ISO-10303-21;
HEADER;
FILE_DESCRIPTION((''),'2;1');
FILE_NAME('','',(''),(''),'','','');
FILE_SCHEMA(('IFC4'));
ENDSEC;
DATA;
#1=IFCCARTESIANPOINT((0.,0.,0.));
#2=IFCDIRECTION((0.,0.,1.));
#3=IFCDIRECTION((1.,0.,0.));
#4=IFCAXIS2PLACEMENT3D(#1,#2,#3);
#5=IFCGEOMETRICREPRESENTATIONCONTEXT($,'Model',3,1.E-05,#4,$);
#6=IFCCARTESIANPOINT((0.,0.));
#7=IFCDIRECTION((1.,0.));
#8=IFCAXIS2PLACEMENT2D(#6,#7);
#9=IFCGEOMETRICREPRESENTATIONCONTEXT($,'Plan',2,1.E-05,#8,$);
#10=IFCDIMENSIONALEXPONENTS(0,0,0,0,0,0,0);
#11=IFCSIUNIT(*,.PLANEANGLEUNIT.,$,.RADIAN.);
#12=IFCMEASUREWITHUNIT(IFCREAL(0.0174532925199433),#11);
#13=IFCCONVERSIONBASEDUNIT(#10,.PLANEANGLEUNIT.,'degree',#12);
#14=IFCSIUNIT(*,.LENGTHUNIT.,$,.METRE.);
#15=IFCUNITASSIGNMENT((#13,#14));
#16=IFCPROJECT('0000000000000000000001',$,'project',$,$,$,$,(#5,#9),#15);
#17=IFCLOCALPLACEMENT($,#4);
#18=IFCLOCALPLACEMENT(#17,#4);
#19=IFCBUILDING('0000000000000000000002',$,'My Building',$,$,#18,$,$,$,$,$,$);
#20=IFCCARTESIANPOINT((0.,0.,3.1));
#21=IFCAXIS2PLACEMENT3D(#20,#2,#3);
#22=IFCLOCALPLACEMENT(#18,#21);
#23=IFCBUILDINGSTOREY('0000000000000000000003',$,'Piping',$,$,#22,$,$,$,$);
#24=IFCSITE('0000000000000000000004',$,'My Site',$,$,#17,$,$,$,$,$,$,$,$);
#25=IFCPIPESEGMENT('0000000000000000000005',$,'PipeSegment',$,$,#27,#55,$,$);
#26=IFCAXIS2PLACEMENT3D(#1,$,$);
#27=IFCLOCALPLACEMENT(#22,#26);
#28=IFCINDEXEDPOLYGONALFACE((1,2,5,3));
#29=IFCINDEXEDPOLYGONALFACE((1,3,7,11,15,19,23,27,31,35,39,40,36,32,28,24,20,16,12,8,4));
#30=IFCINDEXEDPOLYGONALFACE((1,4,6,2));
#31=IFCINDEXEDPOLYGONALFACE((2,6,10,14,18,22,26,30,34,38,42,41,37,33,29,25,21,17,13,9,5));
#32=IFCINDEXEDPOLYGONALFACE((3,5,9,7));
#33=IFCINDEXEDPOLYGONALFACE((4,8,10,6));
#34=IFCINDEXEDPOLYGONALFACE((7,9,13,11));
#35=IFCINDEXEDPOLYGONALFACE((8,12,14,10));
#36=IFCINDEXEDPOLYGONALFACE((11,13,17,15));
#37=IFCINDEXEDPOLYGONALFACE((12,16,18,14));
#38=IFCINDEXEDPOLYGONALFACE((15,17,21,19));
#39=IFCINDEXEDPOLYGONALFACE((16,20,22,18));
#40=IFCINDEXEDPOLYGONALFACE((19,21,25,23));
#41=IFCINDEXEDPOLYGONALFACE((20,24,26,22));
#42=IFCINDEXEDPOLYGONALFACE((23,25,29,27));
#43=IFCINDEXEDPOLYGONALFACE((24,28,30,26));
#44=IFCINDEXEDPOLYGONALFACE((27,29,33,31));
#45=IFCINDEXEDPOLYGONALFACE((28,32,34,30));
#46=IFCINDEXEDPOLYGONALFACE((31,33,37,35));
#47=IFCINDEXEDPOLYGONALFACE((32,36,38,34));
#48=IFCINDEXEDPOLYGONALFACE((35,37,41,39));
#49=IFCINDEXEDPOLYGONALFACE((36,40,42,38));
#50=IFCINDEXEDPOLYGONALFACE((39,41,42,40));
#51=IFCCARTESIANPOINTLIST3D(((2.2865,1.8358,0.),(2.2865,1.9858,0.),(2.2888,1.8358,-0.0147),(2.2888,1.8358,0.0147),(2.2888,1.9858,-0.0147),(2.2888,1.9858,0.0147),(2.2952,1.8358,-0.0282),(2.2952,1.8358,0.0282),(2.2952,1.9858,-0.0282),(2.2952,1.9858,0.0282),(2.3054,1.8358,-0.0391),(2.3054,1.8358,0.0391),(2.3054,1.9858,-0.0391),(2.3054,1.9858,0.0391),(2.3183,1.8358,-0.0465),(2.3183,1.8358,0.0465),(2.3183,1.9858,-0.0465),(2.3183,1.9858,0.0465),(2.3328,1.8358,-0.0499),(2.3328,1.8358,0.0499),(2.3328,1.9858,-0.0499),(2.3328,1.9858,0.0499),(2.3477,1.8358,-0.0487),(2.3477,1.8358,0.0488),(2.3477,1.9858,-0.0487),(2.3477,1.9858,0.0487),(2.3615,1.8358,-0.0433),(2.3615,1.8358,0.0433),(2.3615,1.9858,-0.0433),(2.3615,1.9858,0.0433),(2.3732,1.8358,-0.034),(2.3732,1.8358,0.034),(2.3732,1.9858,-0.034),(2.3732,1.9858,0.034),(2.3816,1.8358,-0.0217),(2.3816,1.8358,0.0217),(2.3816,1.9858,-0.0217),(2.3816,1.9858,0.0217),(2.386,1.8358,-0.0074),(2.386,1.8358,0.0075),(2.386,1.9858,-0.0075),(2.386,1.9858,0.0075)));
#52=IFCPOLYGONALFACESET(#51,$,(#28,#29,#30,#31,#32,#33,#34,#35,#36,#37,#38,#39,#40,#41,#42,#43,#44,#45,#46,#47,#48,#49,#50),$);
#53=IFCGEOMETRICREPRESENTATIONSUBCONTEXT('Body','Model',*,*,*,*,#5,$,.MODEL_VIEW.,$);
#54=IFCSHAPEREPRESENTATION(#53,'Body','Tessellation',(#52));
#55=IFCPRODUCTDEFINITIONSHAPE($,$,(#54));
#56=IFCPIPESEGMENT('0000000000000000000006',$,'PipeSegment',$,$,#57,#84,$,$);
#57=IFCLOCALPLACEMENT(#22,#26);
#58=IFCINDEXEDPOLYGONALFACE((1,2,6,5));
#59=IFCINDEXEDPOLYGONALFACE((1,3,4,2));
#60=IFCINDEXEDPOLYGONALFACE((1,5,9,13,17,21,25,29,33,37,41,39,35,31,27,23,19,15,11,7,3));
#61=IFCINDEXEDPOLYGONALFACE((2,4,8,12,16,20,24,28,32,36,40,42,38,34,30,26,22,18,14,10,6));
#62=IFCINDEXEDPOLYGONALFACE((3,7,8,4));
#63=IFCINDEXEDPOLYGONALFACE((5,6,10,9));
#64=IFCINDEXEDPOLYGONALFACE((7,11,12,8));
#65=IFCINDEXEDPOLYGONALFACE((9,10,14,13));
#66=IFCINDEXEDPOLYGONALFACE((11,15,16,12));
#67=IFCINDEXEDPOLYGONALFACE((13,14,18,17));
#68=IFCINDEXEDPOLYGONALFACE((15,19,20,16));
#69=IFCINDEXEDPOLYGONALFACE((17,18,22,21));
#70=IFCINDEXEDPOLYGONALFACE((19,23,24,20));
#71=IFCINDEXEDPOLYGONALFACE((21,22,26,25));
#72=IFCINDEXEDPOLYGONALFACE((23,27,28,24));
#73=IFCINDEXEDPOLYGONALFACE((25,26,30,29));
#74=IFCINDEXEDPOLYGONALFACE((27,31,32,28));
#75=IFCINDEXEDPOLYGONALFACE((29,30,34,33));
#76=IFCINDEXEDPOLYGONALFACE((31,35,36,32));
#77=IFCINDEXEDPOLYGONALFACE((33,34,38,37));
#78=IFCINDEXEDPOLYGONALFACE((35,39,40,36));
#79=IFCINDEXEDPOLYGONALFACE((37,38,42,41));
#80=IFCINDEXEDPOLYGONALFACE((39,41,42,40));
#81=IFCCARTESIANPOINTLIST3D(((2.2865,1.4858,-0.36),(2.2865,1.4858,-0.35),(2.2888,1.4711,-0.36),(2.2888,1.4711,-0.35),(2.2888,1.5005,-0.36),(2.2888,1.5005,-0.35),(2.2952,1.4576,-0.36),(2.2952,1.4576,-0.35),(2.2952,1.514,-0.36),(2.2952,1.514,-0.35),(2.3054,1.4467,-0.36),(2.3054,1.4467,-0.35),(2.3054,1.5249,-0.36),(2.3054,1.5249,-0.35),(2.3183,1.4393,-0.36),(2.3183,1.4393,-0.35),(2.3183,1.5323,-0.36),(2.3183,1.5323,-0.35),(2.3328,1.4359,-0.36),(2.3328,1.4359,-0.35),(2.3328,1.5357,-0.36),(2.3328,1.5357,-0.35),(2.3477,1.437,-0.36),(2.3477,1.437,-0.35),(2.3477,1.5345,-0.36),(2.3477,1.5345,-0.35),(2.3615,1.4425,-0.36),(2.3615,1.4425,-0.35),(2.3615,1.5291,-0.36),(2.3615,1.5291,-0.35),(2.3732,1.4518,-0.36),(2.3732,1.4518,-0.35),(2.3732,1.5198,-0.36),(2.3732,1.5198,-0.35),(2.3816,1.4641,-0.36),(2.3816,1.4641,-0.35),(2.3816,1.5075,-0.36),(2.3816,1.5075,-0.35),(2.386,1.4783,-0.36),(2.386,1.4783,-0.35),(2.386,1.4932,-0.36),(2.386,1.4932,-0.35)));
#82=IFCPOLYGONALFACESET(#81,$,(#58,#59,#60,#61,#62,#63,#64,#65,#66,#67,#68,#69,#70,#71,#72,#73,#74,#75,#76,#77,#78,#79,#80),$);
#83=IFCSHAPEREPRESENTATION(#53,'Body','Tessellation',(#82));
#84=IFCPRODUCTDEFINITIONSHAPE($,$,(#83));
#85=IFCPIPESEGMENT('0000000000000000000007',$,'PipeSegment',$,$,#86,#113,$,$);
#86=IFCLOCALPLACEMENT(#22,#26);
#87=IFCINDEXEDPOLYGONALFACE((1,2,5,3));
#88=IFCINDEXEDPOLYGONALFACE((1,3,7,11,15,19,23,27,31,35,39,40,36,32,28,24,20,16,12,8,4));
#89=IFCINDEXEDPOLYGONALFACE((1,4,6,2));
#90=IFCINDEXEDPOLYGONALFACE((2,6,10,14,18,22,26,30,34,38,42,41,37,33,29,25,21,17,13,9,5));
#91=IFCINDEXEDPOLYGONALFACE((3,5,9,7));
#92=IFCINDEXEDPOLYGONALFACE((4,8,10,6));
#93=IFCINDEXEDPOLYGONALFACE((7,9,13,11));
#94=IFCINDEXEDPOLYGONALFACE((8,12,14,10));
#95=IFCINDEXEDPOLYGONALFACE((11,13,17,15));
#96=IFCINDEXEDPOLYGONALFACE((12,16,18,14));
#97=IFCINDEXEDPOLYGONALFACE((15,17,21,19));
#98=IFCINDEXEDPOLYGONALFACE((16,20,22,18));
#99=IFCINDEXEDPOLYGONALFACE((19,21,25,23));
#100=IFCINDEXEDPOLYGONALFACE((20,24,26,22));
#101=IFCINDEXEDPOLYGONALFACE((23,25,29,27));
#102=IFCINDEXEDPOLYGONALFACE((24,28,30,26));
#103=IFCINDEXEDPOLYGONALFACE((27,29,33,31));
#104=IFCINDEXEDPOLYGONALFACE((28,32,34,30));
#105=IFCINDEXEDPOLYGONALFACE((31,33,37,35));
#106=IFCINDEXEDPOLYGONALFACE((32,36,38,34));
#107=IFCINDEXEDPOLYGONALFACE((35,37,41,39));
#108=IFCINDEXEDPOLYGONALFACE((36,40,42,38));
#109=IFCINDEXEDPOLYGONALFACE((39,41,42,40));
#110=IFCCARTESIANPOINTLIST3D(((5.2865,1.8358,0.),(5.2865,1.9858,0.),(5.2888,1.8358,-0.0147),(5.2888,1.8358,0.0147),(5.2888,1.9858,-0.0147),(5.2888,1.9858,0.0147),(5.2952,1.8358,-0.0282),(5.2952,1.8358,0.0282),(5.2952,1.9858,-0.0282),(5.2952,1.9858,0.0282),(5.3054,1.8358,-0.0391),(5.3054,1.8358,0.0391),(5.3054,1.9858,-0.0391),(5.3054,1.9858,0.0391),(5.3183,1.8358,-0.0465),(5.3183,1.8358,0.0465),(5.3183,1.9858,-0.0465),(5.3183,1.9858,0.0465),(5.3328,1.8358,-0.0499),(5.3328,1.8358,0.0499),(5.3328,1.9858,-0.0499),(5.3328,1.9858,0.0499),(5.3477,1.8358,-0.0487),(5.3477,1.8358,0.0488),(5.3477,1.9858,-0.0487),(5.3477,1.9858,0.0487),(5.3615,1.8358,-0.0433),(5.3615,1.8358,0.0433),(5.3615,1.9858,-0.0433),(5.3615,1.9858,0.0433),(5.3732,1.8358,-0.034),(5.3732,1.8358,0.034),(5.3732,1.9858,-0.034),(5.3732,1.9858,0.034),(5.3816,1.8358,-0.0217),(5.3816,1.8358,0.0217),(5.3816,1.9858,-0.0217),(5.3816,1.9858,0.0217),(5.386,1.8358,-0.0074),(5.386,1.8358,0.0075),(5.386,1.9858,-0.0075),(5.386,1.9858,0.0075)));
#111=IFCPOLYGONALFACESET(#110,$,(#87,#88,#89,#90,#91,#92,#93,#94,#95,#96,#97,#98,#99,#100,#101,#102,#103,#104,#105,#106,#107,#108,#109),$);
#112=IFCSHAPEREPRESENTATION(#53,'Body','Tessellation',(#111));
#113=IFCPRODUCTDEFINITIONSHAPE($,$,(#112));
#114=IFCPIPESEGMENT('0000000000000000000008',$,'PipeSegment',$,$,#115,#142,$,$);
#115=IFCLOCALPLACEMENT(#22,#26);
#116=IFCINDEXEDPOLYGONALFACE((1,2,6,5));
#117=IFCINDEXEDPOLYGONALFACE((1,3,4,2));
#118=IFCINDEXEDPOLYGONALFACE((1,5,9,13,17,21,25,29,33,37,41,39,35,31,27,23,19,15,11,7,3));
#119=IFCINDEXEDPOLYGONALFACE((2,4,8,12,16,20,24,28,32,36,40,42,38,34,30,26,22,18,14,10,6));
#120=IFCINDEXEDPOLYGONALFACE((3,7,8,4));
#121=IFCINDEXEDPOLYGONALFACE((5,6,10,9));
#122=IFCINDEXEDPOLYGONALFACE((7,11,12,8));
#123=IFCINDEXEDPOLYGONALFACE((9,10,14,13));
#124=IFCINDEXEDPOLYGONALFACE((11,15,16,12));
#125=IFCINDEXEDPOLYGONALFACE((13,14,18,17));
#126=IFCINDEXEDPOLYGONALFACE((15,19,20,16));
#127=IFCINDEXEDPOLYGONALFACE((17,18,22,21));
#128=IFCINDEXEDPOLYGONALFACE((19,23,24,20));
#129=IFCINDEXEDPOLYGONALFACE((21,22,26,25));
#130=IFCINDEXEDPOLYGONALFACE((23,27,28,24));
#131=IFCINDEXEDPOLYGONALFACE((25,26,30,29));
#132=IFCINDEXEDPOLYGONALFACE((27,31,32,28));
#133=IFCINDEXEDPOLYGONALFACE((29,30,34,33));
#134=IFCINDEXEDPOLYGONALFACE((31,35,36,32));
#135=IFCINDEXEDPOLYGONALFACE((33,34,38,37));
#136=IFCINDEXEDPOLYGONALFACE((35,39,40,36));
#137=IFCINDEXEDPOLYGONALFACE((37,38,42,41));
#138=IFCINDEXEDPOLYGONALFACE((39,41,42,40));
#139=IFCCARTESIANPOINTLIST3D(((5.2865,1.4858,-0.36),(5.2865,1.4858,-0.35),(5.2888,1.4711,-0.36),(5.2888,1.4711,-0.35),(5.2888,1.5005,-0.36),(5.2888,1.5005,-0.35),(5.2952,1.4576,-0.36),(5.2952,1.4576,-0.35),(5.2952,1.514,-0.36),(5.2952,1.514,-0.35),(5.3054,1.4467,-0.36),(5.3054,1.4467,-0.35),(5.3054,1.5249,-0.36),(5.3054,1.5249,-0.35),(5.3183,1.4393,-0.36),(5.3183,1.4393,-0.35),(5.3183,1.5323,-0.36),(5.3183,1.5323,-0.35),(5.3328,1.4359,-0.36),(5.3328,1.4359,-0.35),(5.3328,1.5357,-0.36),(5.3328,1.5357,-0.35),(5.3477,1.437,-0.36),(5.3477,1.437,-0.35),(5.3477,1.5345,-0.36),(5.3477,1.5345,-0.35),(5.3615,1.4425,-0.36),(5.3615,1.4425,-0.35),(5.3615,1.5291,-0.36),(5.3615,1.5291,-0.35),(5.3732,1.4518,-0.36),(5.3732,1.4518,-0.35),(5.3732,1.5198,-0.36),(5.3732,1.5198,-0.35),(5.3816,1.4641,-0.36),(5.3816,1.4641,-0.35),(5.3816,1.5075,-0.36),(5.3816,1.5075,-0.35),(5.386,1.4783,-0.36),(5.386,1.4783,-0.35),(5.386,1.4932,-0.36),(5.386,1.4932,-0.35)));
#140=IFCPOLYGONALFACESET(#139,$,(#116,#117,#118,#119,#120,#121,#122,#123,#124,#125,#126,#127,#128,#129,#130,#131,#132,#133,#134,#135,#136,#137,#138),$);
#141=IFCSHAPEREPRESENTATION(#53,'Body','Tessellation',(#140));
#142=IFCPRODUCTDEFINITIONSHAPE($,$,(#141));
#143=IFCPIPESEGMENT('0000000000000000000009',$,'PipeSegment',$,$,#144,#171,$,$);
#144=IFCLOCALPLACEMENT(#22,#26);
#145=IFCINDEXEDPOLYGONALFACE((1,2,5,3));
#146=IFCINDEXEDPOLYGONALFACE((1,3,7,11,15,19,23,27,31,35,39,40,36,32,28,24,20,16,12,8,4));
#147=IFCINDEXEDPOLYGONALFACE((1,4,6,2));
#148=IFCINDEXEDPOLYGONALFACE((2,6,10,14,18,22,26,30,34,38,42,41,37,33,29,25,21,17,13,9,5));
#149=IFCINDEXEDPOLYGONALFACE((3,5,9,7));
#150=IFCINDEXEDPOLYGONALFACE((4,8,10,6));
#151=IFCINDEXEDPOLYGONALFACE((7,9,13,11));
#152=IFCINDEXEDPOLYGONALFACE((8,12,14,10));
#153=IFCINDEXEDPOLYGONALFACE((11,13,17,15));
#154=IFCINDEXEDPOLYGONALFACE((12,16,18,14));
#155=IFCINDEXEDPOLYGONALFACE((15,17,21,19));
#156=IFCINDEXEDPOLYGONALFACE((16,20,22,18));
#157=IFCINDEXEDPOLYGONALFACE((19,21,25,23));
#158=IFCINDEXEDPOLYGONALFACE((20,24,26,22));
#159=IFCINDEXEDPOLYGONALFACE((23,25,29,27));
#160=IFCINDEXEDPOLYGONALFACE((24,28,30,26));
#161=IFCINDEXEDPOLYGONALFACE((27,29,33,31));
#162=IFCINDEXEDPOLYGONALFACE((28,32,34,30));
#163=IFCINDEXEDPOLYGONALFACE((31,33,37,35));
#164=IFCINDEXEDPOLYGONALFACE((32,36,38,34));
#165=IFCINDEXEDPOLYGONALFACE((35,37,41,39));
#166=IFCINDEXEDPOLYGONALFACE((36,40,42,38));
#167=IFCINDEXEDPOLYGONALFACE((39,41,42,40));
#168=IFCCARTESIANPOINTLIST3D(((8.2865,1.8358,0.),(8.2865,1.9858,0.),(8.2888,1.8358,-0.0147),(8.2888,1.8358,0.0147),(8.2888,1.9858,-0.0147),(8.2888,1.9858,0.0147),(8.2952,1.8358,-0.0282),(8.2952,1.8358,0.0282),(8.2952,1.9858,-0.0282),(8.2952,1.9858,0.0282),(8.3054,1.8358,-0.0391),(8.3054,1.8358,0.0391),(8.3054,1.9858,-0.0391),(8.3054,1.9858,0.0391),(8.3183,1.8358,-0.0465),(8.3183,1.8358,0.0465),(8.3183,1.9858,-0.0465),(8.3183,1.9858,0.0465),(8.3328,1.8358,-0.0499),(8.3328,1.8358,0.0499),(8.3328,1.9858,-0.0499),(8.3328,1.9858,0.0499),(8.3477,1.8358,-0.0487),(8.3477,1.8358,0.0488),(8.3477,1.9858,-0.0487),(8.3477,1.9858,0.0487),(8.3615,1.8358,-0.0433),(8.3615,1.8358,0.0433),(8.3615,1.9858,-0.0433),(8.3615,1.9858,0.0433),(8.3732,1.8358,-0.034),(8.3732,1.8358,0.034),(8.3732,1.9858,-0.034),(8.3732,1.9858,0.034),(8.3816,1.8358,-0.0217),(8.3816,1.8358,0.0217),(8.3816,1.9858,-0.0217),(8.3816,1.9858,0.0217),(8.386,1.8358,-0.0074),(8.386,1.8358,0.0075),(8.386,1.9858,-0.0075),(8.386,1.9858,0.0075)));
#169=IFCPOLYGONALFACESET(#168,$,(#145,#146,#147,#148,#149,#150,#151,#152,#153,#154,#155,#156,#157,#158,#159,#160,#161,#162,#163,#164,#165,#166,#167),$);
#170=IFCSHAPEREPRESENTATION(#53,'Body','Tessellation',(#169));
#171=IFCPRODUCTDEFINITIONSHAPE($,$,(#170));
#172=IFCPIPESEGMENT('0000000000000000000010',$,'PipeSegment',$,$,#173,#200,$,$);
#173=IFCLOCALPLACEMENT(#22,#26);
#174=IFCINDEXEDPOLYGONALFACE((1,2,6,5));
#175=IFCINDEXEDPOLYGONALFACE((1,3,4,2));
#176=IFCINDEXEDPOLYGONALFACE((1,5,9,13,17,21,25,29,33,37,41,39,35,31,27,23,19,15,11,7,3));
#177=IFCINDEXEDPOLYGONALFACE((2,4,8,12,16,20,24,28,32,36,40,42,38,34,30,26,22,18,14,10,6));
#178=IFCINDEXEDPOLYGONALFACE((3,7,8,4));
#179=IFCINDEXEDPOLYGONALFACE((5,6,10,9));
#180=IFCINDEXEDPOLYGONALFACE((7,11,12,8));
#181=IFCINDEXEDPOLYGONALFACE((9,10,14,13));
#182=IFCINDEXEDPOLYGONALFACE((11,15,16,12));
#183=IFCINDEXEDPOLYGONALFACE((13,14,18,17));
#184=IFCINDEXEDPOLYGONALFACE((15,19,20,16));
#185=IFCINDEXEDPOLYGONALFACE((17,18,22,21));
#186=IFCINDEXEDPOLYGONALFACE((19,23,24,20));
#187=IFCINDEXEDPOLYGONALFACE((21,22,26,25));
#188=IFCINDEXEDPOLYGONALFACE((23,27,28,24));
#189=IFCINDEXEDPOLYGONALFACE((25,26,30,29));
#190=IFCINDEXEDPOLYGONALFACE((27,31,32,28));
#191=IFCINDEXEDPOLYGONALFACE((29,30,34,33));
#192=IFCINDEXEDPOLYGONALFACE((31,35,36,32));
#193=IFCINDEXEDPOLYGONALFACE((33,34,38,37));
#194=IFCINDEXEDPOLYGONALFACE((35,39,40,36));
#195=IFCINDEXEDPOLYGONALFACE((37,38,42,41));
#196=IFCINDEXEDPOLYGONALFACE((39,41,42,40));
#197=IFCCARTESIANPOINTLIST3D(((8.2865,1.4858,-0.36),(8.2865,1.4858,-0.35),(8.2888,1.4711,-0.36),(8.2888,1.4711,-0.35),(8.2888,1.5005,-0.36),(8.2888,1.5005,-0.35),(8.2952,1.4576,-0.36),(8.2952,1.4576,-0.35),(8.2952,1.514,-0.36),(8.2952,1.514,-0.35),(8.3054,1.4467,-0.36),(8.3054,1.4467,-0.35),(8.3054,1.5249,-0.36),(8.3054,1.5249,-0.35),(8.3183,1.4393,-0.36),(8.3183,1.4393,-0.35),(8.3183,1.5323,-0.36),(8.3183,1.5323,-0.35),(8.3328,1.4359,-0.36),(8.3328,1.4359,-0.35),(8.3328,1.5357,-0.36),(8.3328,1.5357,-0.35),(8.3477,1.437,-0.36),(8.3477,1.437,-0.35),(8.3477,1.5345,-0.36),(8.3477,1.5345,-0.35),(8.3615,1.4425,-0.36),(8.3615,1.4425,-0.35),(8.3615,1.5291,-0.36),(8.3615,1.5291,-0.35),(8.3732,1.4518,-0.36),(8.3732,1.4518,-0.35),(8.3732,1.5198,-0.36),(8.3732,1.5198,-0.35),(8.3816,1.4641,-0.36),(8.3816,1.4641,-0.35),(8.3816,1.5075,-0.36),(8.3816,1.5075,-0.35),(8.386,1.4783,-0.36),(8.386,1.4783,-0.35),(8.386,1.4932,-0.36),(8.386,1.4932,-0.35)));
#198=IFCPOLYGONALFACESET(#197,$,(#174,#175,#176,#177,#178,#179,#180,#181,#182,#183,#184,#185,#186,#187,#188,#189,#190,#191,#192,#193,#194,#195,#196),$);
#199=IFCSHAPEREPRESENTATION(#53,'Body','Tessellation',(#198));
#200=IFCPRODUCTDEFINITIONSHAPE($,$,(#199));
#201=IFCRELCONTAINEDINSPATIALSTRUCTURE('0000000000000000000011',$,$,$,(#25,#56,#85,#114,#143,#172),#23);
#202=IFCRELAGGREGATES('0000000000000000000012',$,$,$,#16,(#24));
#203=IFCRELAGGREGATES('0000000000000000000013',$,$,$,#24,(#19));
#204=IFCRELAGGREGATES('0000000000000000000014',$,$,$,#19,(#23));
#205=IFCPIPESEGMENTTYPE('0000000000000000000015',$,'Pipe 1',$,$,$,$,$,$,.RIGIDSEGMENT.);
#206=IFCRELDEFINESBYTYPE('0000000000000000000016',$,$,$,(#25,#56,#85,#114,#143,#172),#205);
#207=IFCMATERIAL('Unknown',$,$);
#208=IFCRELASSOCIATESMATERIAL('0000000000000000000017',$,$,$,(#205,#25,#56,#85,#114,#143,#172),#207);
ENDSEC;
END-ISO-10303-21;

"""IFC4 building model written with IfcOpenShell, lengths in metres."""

from ifc_helpers import new_model, entity, si_unit, converted_unit, frame, origin_with_axes, origin_2d_with_axis, place, context, subcontext, project, spatial, circle, extrude, material, material_profile, profile_set, profile_usage, type_object, element, save


model = new_model("IFC4")

# Units and contexts
model_context = context("Model", 3, precision=1e-05, world=origin_with_axes())
plan_context = context("Plan", 2, precision=1e-05, world=origin_2d_with_axis())
body_context = subcontext(model_context, "Body", "Model", "MODEL_VIEW")
ifc_project = project(units=[converted_unit("PLANEANGLEUNIT", "degree", entity("IfcReal", 0.0174532925199433), si_unit("PLANEANGLEUNIT", "RADIAN"), dimensions=[0, 0, 0, 0, 0, 0, 0]), si_unit("LENGTHUNIT", "METRE")], contexts=[model_context, plan_context])

# Site, building, storey
site_placement = place(None, origin_with_axes())
site = spatial("IfcSite", under=ifc_project, at=site_placement, Name="My Site")
building_placement = place(site_placement, origin_with_axes())
building = spatial("IfcBuilding", under=site, at=building_placement, Name="My Building")
storey_placement = place(building_placement, frame((0.0, 0.0, 3.1), z_axis=(0.0, 0.0, 1.0), x_axis=(1.0, 0.0, 0.0)))
storey = spatial("IfcBuildingStorey", under=building, at=storey_placement, Name="Piping")

# Pipe segments
ifc_material = material(Name="Unknown")
ifc_material_profile = material_profile(ifc_material, circle(Radius=0.05))
ifc_profile_set = profile_set([ifc_material_profile])
pipe_segment_type = type_object("IfcPipeSegmentType", Name="Pipe 1", PredefinedType="RIGIDSEGMENT", material=ifc_profile_set)
ifc_profile_usage_1 = profile_usage(ifc_profile_set, cardinal=5)
pipe_segment_1_placement = place(storey_placement, frame((2.3365, 1.8358, 0.0), z_axis=(0.0, 1.0, -0.000022), x_axis=(-1.0, 0.0, 0.0)))
element("IfcPipeSegment", 1, at=pipe_segment_1_placement, inside=storey, type_object=pipe_segment_type, material=ifc_profile_usage_1, Name="PipeSegment", context=body_context, shape_type="SweptSolid", body=[
    extrude(circle(Radius=0.05), origin_with_axes(), (0.0, 0.0, 1.0), 0.15),
])
ifc_profile_usage_2 = profile_usage(ifc_profile_set, cardinal=5)
pipe_segment_2_placement = place(storey_placement, frame((2.3365, 1.4858, -0.35), z_axis=(0.0, 0.0, -1.0), x_axis=(-1.0, 0.0, 0.0)))
element("IfcPipeSegment", 2, at=pipe_segment_2_placement, inside=storey, type_object=pipe_segment_type, material=ifc_profile_usage_2, Name="PipeSegment", context=body_context, shape_type="SweptSolid", body=[
    extrude(circle(Radius=0.05), origin_with_axes(), (0.0, 0.0, 1.0), 0.01),
])
ifc_profile_usage_3 = profile_usage(ifc_profile_set, cardinal=5)
pipe_segment_3_placement = place(storey_placement, frame((5.3365, 1.8358, 0.0), z_axis=(0.0, 1.0, -0.000022), x_axis=(-1.0, 0.0, 0.0)))
element("IfcPipeSegment", 3, at=pipe_segment_3_placement, inside=storey, type_object=pipe_segment_type, material=ifc_profile_usage_3, Name="PipeSegment", context=body_context, shape_type="SweptSolid", body=[
    extrude(circle(Radius=0.05), origin_with_axes(), (0.0, 0.0, 1.0), 0.15),
])
ifc_profile_usage_4 = profile_usage(ifc_profile_set, cardinal=5)
pipe_segment_4_placement = place(storey_placement, frame((5.3365, 1.4858, -0.35), z_axis=(0.0, 0.0, -1.0), x_axis=(-1.0, 0.0, 0.0)))
element("IfcPipeSegment", 4, at=pipe_segment_4_placement, inside=storey, type_object=pipe_segment_type, material=ifc_profile_usage_4, Name="PipeSegment", context=body_context, shape_type="SweptSolid", body=[
    extrude(circle(Radius=0.05), origin_with_axes(), (0.0, 0.0, 1.0), 0.01),
])
ifc_profile_usage_5 = profile_usage(ifc_profile_set, cardinal=5)
pipe_segment_5_placement = place(storey_placement, frame((8.3365, 1.8358, 0.0), z_axis=(0.0, 1.0, -0.000022), x_axis=(-1.0, 0.0, 0.0)))
element("IfcPipeSegment", 5, at=pipe_segment_5_placement, inside=storey, type_object=pipe_segment_type, material=ifc_profile_usage_5, Name="PipeSegment", context=body_context, shape_type="SweptSolid", body=[
    extrude(circle(Radius=0.05), origin_with_axes(), (0.0, 0.0, 1.0), 0.15),
])
ifc_profile_usage_6 = profile_usage(ifc_profile_set, cardinal=5)
pipe_segment_6_placement = place(storey_placement, frame((8.3365, 1.4858, -0.35), z_axis=(0.0, 0.0, -1.0), x_axis=(-1.0, 0.0, 0.0)))
element("IfcPipeSegment", 6, at=pipe_segment_6_placement, inside=storey, type_object=pipe_segment_type, material=ifc_profile_usage_6, Name="PipeSegment", context=body_context, shape_type="SweptSolid", body=[
    extrude(circle(Radius=0.05), origin_with_axes(), (0.0, 0.0, 1.0), 0.01),
])

save(model, "model.ifc")
